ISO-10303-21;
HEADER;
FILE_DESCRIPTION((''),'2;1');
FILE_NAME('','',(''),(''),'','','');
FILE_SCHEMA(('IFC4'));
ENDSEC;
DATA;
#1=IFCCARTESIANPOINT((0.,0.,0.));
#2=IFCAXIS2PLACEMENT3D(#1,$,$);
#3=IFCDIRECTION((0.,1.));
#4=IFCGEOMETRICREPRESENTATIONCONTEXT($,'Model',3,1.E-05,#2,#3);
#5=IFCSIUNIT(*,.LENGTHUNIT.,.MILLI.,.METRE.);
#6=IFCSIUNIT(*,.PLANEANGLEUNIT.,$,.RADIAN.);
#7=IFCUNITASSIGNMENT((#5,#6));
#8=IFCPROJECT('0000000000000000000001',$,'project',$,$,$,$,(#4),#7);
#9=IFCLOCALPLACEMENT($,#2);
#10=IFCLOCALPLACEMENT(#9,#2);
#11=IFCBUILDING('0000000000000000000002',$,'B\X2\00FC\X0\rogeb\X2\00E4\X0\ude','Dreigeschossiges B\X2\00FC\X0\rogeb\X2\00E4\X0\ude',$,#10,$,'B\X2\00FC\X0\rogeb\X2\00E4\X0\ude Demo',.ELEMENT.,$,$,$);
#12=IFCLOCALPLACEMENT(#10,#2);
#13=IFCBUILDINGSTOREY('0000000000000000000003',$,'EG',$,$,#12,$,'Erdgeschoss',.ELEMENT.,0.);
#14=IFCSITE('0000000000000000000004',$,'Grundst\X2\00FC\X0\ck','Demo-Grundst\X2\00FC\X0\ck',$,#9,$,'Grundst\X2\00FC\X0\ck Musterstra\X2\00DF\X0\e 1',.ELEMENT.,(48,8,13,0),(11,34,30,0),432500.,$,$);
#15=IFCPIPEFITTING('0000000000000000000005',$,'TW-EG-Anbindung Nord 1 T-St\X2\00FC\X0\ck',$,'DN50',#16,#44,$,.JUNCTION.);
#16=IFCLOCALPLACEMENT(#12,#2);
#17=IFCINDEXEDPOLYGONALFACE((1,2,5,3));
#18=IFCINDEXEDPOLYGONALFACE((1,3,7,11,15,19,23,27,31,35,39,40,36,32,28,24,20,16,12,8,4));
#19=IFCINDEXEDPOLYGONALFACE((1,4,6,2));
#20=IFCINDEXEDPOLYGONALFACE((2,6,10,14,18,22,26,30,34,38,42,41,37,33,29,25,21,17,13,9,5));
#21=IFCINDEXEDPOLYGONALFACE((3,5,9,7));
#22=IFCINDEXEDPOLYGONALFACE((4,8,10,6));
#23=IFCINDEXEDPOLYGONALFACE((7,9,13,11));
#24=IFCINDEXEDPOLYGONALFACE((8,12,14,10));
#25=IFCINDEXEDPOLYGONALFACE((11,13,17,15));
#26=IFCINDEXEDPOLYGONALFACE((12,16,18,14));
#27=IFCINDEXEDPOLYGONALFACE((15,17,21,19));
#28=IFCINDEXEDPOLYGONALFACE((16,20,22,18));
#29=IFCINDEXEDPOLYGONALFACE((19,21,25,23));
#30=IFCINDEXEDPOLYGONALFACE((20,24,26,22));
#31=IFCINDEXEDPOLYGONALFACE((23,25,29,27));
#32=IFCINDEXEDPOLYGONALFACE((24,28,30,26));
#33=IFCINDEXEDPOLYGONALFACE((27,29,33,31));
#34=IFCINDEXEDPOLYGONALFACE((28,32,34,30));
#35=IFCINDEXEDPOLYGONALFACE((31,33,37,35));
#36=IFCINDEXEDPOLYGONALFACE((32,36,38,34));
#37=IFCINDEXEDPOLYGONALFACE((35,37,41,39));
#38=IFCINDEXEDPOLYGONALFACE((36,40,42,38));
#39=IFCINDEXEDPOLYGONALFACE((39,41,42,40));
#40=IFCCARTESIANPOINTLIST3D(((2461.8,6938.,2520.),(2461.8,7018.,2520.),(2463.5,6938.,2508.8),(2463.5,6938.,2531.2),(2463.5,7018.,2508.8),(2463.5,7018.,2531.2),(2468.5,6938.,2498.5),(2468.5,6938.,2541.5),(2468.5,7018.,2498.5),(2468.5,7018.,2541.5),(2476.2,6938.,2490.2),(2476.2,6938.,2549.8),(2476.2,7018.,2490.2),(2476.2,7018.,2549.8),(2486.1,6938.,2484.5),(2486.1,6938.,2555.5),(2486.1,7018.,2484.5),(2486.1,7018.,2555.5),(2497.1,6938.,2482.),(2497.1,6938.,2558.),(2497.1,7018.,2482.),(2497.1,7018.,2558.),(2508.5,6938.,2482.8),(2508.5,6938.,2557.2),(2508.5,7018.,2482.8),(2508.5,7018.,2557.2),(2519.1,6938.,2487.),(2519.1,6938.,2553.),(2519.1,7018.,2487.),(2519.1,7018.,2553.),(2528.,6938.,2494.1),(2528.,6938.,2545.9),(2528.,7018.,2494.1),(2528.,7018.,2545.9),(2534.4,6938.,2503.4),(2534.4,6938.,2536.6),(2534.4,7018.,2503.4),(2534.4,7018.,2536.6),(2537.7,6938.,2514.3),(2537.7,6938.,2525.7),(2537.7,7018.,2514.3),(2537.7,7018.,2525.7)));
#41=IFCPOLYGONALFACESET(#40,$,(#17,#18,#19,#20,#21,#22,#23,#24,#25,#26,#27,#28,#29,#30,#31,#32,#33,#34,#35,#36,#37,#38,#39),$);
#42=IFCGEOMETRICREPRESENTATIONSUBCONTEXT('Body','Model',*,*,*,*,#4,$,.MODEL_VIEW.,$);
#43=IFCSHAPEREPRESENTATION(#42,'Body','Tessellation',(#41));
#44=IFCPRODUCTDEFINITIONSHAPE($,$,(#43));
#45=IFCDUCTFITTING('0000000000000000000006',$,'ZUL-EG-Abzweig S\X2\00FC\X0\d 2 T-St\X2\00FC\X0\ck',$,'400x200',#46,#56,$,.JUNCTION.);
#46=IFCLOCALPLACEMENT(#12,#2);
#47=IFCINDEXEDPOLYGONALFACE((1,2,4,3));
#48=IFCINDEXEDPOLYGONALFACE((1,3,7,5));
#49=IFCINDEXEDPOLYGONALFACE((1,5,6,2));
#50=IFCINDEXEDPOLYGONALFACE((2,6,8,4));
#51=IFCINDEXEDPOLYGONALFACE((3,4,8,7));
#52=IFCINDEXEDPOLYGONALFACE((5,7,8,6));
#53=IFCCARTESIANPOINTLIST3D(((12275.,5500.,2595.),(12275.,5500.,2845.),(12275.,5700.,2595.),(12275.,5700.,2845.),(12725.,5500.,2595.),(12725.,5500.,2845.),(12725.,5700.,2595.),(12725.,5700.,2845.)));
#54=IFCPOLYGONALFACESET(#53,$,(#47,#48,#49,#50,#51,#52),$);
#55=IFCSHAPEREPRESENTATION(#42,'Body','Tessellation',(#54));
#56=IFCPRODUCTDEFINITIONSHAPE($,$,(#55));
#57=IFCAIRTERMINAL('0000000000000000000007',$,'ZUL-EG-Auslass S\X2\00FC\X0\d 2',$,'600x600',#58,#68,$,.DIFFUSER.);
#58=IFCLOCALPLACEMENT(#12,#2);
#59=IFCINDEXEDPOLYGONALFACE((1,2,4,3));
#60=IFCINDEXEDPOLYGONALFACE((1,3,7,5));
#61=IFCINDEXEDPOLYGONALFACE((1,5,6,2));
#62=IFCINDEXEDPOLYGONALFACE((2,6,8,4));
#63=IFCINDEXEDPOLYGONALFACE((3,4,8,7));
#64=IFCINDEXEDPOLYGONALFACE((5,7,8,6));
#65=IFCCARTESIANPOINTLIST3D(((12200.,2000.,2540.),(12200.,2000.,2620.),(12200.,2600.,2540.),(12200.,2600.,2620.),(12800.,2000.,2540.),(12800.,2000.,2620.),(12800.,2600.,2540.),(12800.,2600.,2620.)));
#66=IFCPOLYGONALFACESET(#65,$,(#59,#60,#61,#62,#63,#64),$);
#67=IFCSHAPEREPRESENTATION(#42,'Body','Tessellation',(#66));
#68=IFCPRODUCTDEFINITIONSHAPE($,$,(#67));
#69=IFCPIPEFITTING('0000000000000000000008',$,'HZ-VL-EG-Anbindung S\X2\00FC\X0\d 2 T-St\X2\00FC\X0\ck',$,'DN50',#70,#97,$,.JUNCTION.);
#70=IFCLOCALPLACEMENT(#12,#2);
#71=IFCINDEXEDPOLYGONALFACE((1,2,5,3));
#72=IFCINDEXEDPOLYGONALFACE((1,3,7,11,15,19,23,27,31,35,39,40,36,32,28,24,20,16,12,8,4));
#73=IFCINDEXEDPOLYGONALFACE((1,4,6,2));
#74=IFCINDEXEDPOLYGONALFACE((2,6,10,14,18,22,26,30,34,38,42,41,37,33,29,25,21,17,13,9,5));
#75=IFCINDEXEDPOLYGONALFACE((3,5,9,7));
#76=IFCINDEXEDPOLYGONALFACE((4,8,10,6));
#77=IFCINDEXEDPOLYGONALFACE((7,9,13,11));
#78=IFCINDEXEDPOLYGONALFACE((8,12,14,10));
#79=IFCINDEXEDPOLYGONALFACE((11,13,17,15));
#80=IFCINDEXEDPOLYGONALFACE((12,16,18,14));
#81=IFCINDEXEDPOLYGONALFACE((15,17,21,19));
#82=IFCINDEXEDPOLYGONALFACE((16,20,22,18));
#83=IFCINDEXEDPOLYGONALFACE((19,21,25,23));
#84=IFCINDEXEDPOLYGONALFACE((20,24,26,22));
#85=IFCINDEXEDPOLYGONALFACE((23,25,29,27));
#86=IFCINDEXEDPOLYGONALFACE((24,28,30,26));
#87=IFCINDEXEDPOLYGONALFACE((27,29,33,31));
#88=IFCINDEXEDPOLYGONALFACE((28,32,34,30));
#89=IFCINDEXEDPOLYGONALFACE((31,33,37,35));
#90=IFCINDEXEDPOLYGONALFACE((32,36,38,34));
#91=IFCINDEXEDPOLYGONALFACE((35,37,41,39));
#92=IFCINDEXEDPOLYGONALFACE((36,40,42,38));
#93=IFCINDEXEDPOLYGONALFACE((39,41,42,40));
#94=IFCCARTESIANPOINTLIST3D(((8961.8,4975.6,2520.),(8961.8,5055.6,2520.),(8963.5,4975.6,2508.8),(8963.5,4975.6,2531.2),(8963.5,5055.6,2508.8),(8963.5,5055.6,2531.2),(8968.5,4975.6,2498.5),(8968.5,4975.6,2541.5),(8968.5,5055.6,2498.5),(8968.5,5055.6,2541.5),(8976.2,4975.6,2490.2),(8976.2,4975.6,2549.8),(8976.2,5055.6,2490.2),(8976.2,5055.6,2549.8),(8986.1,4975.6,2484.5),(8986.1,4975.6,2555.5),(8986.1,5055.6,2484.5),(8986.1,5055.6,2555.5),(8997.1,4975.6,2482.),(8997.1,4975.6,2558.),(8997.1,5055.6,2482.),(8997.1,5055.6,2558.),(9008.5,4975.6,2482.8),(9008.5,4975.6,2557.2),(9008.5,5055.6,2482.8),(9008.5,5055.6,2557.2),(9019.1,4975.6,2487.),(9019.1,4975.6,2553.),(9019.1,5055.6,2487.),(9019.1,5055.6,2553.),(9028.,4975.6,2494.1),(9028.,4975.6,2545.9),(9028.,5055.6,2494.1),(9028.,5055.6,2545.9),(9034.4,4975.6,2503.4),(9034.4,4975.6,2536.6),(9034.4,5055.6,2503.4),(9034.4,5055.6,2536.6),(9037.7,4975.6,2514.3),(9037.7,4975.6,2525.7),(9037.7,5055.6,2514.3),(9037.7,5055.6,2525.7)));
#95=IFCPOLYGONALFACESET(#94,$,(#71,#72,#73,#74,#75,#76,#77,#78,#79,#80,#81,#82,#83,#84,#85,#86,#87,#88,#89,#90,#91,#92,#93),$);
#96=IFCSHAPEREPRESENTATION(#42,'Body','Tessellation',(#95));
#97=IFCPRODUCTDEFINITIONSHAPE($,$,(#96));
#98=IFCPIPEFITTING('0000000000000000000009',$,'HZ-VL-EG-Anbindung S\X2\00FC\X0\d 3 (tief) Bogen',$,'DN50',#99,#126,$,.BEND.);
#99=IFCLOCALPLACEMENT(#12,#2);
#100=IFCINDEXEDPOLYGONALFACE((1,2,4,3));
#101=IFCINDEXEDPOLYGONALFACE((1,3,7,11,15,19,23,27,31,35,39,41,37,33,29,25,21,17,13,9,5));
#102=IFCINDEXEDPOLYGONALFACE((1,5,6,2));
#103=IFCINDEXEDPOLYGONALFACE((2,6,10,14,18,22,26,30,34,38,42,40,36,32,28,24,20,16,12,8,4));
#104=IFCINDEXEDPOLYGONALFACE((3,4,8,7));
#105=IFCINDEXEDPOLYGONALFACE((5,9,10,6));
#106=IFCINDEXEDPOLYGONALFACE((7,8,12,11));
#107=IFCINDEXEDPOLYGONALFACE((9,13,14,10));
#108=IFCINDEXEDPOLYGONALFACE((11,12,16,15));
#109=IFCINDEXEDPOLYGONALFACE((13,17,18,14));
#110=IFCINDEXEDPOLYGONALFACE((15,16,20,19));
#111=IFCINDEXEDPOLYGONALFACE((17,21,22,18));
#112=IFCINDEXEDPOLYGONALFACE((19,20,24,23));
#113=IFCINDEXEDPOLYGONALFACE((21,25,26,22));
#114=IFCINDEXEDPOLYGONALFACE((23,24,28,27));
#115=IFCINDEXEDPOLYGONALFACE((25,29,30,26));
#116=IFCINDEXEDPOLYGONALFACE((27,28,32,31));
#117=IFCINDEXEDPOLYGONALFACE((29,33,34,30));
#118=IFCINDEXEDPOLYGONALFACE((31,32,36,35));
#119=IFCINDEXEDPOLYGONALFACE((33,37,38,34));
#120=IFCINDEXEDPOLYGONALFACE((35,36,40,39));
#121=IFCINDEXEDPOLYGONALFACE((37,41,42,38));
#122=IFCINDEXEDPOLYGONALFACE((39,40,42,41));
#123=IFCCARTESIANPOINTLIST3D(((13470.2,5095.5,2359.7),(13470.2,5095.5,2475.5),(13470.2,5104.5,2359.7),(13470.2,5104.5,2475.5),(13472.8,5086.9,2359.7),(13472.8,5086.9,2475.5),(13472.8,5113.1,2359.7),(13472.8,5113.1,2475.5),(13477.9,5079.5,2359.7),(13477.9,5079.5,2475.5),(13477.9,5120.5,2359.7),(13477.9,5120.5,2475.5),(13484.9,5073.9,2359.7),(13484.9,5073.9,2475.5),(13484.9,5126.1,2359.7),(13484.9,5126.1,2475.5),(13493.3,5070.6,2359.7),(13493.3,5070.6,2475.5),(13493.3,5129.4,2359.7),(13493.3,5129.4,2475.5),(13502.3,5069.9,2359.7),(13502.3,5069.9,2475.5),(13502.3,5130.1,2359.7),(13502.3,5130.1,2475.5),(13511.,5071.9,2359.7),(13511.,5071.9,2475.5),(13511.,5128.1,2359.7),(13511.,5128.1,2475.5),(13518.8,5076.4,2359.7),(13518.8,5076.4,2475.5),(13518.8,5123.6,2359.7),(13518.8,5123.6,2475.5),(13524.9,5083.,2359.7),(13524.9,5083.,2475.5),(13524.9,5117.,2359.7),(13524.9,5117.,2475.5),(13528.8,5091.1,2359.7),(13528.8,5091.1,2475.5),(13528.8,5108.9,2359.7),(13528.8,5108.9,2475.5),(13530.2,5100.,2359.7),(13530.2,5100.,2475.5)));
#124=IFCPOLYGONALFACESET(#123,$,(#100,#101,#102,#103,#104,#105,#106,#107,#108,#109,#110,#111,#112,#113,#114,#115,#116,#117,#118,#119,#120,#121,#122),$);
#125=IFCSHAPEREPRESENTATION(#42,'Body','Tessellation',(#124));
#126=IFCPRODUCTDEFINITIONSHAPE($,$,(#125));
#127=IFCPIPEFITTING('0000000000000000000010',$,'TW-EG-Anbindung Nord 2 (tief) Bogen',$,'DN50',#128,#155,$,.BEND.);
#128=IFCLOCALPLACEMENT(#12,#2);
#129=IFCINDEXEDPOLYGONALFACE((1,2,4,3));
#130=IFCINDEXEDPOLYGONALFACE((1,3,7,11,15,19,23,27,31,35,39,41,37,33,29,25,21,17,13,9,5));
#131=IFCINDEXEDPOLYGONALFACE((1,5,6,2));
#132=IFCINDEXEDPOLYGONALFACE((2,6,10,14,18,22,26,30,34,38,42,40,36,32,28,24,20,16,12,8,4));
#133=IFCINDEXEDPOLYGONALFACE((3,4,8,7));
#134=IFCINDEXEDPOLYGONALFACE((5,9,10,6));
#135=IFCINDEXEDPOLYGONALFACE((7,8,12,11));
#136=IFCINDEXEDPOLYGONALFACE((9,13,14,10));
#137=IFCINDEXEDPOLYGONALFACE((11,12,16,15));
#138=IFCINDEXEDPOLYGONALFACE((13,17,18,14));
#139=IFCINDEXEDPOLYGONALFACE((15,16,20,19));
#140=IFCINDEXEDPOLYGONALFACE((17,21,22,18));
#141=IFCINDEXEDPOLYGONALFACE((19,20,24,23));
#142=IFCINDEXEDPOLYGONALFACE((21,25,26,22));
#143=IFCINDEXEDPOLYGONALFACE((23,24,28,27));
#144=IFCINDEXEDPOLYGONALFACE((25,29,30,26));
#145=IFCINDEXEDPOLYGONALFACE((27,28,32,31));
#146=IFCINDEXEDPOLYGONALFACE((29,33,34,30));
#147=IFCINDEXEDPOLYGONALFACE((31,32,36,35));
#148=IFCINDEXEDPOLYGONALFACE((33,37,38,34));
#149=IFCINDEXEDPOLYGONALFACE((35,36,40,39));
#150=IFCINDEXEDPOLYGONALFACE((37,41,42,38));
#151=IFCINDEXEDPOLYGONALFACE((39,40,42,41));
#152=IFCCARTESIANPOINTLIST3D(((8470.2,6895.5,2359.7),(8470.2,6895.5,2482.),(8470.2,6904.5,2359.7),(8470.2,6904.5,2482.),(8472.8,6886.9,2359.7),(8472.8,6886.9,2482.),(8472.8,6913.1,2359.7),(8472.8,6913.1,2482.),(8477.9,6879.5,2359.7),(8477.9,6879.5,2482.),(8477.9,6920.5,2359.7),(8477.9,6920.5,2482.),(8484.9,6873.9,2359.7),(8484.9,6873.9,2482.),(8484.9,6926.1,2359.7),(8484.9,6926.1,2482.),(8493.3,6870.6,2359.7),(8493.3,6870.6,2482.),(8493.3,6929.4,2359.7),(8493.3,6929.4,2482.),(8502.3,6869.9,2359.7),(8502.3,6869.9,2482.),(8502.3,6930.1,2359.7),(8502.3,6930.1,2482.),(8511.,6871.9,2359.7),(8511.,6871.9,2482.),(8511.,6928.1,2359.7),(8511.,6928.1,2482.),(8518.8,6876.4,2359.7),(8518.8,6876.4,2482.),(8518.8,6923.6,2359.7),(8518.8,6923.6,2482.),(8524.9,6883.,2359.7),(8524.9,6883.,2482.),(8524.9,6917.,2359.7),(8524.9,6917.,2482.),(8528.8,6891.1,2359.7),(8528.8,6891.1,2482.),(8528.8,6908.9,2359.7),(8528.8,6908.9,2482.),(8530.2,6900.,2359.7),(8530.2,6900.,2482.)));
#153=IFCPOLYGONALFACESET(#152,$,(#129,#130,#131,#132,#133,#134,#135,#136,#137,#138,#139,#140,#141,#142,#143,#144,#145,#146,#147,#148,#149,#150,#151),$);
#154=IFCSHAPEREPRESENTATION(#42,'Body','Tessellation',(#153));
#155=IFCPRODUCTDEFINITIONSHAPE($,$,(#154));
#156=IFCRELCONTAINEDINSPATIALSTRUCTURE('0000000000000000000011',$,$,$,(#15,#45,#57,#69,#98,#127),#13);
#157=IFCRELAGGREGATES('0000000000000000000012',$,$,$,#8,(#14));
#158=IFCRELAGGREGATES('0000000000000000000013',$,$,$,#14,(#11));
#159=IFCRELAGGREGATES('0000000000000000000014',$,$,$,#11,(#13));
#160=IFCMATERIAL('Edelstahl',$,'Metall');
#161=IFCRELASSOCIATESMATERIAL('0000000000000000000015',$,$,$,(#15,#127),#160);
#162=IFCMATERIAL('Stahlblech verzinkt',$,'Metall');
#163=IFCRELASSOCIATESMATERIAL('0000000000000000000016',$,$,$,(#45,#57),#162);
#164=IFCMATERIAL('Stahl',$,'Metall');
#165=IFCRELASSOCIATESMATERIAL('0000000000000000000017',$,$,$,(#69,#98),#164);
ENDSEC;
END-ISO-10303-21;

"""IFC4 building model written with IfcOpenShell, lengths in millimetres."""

from ifc_helpers import new_model, si_unit, direction, frame, origin, origin_2d, place, context, subcontext, project, spatial, rectangle, circle, extrude, material, element, save


model = new_model("IFC4")

# Units and contexts
model_context = context("Model", 3, precision=1e-05, world=origin(), true_north=direction((0.0, 1.0)))
body_context = subcontext(model_context, "Body", "Model", "MODEL_VIEW")
ifc_project = project(units=[si_unit("LENGTHUNIT", "METRE", prefix="MILLI"), si_unit("PLANEANGLEUNIT", "RADIAN")], contexts=[model_context])

# Site, building, storey
site_placement = place(None, origin())
site = spatial("IfcSite", under=ifc_project, at=site_placement, Name="Grundstück", Description="Demo-Grundstück", LongName="Grundstück Musterstraße 1", CompositionType="ELEMENT", RefLatitude=(48, 8, 13, 0), RefLongitude=(11, 34, 30, 0), RefElevation=432500.0)
building_placement = place(site_placement, origin())
building = spatial("IfcBuilding", under=site, at=building_placement, Name="Bürogebäude", Description="Dreigeschossiges Bürogebäude", LongName="Bürogebäude Demo", CompositionType="ELEMENT")
storey_placement = place(building_placement, origin())
storey = spatial("IfcBuildingStorey", under=building, at=storey_placement, Name="EG", LongName="Erdgeschoss", CompositionType="ELEMENT", Elevation=0.0)

# Shared definitions
ifc_material_1 = material(Name="Stahlblech verzinkt", Category="Metall")

# Shared definitions
ifc_material_2 = material(Name="Stahl", Category="Metall")
ifc_material_3 = material(Name="Edelstahl", Category="Metall")

# Pipe fitting
pipe_fitting_1_placement = place(storey_placement, frame((2500.0, 6938.1, 2520.0)))
element("IfcPipeFitting", 1, at=pipe_fitting_1_placement, inside=storey, material=ifc_material_3, Name="TW-EG-Anbindung Nord 1 T-Stück", ObjectType="DN50", PredefinedType="JUNCTION", context=body_context, shape_type="SweptSolid", body=[
    extrude(circle(Radius=38.1, at=origin_2d()), frame((0.0, 0.0, 0.0), z_axis=(0.0, 1.0, 0.0), x_axis=(-1.0, 0.0, 0.0)), (0.0, 0.0, 1.0), 80.0),
])

# Duct fitting
duct_fitting_1_placement = place(storey_placement, frame((12500.0, 5500.0, 2720.0)))
element("IfcDuctFitting", 2, at=duct_fitting_1_placement, inside=storey, material=ifc_material_1, Name="ZUL-EG-Abzweig Süd 2 T-Stück", ObjectType="400x200", PredefinedType="JUNCTION", context=body_context, shape_type="SweptSolid", body=[
    extrude(rectangle(XDim=450.0, YDim=250.0, at=origin_2d()), frame((0.0, 0.0, 0.0), z_axis=(0.0, 1.0, 0.0), x_axis=(-1.0, 0.0, 0.0)), (0.0, 0.0, 1.0), 200.0),
])

# Air terminal
air_terminal_1_placement = place(storey_placement, frame((12500.0, 2300.0, 2540.0)))
element("IfcAirTerminal", 3, at=air_terminal_1_placement, inside=storey, material=ifc_material_1, Name="ZUL-EG-Auslass Süd 2", ObjectType="600x600", PredefinedType="DIFFUSER", context=body_context, shape_type="SweptSolid", body=[
    extrude(rectangle(XDim=600.0, YDim=600.0, at=origin_2d()), origin(), (0.0, 0.0, 1.0), 80.0),
])

# Pipe fittings
pipe_fitting_2_placement = place(storey_placement, frame((9000.0, 4975.6, 2520.0)))
element("IfcPipeFitting", 4, at=pipe_fitting_2_placement, inside=storey, material=ifc_material_2, Name="HZ-VL-EG-Anbindung Süd 2 T-Stück", ObjectType="DN50", PredefinedType="JUNCTION", context=body_context, shape_type="SweptSolid", body=[
    extrude(circle(Radius=38.1, at=origin_2d()), frame((0.0, 0.0, 0.0), z_axis=(0.0, 1.0, 0.0), x_axis=(-1.0, 0.0, 0.0)), (0.0, 0.0, 1.0), 80.0),
])
pipe_fitting_3_placement = place(storey_placement, frame((13500.0, 5100.0, 2359.7)))
element("IfcPipeFitting", 5, at=pipe_fitting_3_placement, inside=storey, material=ifc_material_2, Name="HZ-VL-EG-Anbindung Süd 3 (tief) Bogen", ObjectType="DN50", PredefinedType="BEND", context=body_context, shape_type="SweptSolid", body=[
    extrude(circle(Radius=30.1, at=origin_2d()), origin(), (0.0, 0.0, 1.0), 115.8),
])
pipe_fitting_4_placement = place(storey_placement, frame((8500.0, 6900.0, 2359.7)))
element("IfcPipeFitting", 6, at=pipe_fitting_4_placement, inside=storey, material=ifc_material_3, Name="TW-EG-Anbindung Nord 2 (tief) Bogen", ObjectType="DN50", PredefinedType="BEND", context=body_context, shape_type="SweptSolid", body=[
    extrude(circle(Radius=30.1, at=origin_2d()), origin(), (0.0, 0.0, 1.0), 122.2),
])

save(model, "model.ifc")
